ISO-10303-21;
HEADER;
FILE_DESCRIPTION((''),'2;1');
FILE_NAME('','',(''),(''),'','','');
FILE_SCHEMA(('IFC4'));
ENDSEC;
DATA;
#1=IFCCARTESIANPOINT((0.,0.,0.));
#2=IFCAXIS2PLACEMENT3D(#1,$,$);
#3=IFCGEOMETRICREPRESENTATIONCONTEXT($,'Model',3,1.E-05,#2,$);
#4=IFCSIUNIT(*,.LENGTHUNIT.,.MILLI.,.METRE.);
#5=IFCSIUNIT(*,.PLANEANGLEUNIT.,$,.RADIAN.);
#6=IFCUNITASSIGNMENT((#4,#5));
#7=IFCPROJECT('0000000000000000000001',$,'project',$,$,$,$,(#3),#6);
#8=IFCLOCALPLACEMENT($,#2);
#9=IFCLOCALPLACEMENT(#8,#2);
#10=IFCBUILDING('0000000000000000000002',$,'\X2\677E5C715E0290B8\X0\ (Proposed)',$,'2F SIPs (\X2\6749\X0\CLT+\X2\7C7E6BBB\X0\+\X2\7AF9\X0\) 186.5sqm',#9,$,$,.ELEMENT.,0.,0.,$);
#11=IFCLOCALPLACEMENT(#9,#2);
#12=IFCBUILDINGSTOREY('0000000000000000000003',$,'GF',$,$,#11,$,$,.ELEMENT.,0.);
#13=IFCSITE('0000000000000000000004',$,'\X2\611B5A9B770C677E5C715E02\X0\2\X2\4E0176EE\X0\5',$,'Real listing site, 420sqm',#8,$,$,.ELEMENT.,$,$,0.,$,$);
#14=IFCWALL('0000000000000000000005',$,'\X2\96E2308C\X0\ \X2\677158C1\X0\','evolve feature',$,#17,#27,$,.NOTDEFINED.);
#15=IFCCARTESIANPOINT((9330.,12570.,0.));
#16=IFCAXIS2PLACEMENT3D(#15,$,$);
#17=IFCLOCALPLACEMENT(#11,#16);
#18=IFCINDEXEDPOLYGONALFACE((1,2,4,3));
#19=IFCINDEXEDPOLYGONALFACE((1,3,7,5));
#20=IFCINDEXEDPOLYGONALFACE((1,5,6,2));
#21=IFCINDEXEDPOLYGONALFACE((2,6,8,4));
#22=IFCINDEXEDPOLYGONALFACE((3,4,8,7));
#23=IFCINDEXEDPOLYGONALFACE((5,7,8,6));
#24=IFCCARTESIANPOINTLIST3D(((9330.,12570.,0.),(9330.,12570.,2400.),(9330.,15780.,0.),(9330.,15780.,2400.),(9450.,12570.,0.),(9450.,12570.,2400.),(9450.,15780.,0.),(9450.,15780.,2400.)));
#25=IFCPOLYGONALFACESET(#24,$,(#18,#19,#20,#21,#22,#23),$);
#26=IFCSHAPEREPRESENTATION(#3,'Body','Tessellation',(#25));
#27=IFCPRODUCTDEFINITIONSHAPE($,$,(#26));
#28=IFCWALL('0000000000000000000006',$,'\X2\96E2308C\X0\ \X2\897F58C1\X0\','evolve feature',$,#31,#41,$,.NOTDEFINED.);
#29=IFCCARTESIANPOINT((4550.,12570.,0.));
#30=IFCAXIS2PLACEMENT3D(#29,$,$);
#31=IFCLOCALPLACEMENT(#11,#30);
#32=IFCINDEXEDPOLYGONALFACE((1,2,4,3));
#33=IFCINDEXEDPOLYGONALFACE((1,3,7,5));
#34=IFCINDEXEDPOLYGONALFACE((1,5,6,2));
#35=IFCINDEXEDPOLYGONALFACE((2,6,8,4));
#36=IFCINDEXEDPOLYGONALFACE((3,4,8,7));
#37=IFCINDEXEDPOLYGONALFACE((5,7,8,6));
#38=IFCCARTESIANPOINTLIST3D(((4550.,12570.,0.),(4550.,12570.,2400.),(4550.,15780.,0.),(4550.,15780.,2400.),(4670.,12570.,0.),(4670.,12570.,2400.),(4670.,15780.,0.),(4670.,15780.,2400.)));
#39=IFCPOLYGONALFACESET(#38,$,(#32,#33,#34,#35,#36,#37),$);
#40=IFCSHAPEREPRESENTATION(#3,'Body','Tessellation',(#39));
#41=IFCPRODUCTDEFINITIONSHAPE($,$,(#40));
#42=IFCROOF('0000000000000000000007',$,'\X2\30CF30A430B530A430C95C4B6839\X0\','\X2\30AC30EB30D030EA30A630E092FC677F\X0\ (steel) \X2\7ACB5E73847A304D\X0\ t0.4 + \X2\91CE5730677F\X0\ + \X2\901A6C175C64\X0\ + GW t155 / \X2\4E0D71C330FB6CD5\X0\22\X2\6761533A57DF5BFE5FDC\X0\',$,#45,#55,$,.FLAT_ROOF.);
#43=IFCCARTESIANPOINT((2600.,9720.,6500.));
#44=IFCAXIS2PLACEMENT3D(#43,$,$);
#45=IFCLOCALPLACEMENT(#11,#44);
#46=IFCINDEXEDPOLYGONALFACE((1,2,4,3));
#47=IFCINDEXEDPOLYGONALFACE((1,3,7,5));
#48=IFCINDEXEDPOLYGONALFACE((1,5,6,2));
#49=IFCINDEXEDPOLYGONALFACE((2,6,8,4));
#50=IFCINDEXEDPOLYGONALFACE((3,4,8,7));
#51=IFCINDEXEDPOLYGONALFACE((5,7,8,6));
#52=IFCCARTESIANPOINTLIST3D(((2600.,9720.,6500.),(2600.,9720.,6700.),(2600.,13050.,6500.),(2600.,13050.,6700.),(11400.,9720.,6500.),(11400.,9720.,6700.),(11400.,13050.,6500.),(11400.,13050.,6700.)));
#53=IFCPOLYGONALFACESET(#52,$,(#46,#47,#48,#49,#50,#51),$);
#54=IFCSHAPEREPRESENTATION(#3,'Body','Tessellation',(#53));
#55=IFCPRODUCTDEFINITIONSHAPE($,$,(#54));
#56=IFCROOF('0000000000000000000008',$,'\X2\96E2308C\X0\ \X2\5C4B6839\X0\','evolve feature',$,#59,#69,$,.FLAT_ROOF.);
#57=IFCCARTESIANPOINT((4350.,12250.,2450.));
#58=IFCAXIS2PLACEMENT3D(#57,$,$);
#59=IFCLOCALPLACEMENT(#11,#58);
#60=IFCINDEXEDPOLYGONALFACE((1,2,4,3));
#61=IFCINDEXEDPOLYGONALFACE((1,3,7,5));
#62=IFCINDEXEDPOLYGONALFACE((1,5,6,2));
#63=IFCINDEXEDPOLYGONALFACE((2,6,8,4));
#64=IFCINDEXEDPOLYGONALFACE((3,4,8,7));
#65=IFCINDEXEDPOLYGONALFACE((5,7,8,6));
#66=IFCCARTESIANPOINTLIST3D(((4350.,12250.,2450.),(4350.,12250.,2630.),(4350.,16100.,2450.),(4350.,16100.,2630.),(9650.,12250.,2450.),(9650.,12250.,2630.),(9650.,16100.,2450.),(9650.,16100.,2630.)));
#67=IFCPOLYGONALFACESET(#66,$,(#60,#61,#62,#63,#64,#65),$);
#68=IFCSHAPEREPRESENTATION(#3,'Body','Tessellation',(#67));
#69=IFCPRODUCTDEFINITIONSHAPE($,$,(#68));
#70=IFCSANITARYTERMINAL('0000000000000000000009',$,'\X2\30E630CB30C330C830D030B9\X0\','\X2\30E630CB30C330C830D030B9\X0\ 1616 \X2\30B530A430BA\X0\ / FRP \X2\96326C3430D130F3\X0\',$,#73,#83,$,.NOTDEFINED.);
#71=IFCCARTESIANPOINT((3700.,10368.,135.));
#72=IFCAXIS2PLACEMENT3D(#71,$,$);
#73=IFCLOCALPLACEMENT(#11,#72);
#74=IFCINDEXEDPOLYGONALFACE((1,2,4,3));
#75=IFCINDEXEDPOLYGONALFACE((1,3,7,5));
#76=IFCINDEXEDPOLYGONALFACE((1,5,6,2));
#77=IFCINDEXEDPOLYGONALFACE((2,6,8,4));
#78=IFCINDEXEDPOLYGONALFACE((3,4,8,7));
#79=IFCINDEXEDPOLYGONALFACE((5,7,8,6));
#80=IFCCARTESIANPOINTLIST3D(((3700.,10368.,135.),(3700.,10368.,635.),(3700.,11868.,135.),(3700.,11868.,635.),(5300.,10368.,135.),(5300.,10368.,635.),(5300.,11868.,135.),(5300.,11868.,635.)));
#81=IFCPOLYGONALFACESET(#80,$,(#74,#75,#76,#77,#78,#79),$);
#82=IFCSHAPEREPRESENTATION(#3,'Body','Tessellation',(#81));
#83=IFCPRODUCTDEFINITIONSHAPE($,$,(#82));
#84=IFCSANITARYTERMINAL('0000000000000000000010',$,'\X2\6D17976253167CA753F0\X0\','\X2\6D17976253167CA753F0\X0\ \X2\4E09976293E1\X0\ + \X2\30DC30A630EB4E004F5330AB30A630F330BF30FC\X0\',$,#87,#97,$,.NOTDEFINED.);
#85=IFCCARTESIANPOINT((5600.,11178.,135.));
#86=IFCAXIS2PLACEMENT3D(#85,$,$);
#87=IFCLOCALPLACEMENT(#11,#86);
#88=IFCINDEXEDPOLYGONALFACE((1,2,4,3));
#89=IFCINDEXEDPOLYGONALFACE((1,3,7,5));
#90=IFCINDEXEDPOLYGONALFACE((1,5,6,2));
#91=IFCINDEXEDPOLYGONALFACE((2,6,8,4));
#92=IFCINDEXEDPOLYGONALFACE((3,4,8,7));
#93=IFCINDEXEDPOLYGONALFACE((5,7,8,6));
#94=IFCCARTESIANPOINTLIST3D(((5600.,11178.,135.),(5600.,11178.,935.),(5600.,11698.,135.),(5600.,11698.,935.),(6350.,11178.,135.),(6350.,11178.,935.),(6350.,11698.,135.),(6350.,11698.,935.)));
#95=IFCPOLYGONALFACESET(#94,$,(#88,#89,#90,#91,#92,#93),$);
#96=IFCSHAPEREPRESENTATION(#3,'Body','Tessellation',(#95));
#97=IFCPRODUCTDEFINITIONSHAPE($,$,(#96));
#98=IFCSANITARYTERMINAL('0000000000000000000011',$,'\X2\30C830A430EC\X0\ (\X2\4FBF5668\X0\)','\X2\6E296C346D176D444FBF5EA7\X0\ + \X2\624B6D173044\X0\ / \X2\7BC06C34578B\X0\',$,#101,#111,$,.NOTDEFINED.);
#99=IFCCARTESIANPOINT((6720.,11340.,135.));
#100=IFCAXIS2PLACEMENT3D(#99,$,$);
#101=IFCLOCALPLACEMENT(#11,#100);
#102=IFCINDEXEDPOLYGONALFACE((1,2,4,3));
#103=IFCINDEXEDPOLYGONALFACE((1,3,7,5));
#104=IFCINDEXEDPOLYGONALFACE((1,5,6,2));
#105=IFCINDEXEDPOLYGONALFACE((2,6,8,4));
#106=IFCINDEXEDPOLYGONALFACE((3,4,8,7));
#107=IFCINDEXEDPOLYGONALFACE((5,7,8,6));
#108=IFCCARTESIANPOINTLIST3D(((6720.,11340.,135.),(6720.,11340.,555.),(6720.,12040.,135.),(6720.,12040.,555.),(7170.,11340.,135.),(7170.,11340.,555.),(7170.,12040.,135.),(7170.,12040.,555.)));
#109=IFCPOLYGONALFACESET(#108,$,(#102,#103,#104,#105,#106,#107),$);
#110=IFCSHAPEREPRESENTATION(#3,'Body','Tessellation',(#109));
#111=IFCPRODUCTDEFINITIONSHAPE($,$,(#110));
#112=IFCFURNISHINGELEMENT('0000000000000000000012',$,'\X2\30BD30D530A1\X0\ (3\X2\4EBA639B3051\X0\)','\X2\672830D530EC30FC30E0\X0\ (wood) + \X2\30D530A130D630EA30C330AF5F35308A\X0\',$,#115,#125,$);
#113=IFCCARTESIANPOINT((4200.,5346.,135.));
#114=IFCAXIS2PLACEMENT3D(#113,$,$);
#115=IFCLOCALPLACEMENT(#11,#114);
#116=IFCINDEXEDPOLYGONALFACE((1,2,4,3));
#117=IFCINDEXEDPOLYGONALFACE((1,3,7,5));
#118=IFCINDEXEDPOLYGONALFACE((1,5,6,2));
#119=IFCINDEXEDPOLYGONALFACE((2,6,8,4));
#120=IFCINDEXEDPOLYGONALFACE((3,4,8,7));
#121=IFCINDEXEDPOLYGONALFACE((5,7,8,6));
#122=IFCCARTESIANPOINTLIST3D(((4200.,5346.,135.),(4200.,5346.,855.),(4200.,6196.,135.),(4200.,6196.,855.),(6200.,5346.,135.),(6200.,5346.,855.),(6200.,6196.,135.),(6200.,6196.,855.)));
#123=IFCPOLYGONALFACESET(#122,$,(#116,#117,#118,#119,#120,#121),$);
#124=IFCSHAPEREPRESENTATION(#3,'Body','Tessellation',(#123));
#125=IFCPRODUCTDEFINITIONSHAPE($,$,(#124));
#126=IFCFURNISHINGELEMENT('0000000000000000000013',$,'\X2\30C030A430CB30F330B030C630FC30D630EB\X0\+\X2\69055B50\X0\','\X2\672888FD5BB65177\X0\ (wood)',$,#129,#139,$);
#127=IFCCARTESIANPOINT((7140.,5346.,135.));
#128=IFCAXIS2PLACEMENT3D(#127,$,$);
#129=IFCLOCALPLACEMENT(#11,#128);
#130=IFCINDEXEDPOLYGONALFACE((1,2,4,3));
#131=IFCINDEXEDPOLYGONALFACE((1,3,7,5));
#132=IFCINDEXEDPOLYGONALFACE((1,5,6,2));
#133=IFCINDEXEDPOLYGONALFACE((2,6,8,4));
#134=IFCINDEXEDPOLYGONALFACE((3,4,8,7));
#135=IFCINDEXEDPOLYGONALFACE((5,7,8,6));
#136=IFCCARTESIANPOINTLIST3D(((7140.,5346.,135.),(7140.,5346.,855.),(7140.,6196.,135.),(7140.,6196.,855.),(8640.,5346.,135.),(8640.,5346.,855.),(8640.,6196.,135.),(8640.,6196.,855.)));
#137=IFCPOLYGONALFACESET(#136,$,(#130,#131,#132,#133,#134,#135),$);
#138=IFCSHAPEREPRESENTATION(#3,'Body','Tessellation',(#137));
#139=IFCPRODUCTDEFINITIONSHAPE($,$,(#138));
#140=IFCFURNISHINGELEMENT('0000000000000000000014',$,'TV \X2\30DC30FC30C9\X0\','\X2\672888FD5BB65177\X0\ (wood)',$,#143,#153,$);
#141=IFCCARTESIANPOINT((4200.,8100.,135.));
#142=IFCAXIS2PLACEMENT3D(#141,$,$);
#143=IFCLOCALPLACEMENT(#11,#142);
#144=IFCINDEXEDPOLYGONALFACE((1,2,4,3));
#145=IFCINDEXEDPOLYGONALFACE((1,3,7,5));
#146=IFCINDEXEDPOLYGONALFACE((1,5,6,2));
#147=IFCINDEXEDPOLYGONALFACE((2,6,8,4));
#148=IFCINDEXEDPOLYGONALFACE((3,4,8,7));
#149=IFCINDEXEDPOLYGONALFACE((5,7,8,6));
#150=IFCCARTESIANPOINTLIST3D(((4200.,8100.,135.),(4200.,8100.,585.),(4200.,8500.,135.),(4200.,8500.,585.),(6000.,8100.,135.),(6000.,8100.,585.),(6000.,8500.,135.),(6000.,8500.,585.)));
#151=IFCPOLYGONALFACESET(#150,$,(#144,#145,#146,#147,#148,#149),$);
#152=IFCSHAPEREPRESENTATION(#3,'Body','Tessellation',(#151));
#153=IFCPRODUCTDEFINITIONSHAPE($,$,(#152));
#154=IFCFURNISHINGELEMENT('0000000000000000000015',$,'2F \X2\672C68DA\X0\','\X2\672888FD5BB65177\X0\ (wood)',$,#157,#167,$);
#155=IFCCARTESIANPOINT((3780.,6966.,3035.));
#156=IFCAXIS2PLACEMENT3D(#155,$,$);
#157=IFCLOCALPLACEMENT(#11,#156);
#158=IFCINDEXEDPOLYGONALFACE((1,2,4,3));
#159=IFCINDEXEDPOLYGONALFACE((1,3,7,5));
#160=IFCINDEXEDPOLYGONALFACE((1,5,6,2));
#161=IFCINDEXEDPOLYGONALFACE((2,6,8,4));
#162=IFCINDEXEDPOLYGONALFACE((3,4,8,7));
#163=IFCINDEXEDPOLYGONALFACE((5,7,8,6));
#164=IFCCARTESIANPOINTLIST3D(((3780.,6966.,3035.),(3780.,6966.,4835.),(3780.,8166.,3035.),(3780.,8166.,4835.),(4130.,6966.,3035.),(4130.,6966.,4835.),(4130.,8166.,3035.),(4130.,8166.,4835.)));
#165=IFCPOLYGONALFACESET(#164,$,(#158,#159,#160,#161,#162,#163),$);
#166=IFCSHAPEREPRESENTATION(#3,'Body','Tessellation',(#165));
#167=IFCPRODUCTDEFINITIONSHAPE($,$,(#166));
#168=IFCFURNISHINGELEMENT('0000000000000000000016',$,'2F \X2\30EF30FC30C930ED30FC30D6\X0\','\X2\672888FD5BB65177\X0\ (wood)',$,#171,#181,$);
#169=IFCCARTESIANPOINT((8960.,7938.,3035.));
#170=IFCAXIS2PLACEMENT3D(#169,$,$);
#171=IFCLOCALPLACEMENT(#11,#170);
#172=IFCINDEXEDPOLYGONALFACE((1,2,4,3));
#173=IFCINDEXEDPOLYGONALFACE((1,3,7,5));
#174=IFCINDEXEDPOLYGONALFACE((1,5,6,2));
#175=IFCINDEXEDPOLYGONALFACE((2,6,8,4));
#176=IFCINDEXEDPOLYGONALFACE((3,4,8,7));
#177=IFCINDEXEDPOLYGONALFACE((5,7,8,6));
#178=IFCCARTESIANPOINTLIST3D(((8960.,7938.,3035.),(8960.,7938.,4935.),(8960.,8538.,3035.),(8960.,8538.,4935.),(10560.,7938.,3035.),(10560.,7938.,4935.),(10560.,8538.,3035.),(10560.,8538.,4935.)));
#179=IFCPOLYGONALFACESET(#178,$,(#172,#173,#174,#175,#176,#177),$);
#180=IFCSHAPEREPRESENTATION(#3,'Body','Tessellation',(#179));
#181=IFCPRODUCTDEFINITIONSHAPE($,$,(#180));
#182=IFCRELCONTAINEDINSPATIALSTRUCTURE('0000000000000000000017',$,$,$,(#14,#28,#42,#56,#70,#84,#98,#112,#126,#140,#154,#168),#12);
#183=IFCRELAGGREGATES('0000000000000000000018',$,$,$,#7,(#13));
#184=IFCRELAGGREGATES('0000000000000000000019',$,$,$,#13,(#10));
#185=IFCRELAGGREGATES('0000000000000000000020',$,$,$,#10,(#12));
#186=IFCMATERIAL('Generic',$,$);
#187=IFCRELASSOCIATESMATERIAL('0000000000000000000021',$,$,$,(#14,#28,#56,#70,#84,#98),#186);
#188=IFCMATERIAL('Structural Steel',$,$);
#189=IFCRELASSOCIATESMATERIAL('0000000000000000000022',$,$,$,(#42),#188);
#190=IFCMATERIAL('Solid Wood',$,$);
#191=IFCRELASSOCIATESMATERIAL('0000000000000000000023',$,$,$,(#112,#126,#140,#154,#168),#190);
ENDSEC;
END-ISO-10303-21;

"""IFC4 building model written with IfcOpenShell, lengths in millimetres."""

from ifc_helpers import new_model, si_unit, frame, frame_2d, origin, place, context, project, spatial, rectangle, extrude, material, element, save


model = new_model("IFC4")

# Units and contexts
model_context = context("Model", 3, precision=1e-05, world=origin())
ifc_project = project(units=[si_unit("LENGTHUNIT", "METRE", prefix="MILLI"), si_unit("PLANEANGLEUNIT", "RADIAN")], contexts=[model_context])

# Site, building, storey
site_placement = place(None, origin())
site = spatial("IfcSite", under=ifc_project, at=site_placement, Name="愛媛県松山市2丁目5", ObjectType="Real listing site, 420sqm", CompositionType="ELEMENT", RefElevation=0.0)
building_placement = place(site_placement, origin())
building = spatial("IfcBuilding", under=site, at=building_placement, Name="松山市邸 (Proposed)", ObjectType="2F SIPs (杉CLT+籾殻+竹) 186.5sqm", CompositionType="ELEMENT", ElevationOfRefHeight=0.0, ElevationOfTerrain=0.0)
storey_placement = place(building_placement, origin())
storey = spatial("IfcBuildingStorey", under=building, at=storey_placement, Name="GF", CompositionType="ELEMENT", Elevation=0.0)

# Shared definitions
ifc_material_1 = material(Name="Generic")

# Shared definitions
ifc_material_2 = material(Name="Solid Wood")

# Walls
wall_1_placement = place(storey_placement, frame((9330.0, 12570.0, 0.0)))
element("IfcWall", 1, at=wall_1_placement, inside=storey, material=ifc_material_1, Name="離れ 東壁", Description="evolve feature", PredefinedType="NOTDEFINED", context=model_context, shape_type="SweptSolid", body=[
    extrude(rectangle(XDim=120.0, YDim=3210.0, at=frame_2d((60.0, 1605.0))), frame((9330.0, 12570.0, 0.0)), (0.0, 0.0, 1.0), 2400.0),
])
wall_2_placement = place(storey_placement, frame((4550.0, 12570.0, 0.0)))
element("IfcWall", 2, at=wall_2_placement, inside=storey, material=ifc_material_1, Name="離れ 西壁", Description="evolve feature", PredefinedType="NOTDEFINED", context=model_context, shape_type="SweptSolid", body=[
    extrude(rectangle(XDim=120.0, YDim=3210.0, at=frame_2d((60.0, 1605.0))), frame((4550.0, 12570.0, 0.0)), (0.0, 0.0, 1.0), 2400.0),
])

# Roofs
ifc_material_3 = material(Name="Structural Steel")
roof_1_placement = place(storey_placement, frame((2600.0, 9720.0, 6500.0)))
element("IfcRoof", 3, at=roof_1_placement, inside=storey, material=ifc_material_3, Name="ハイサイド屋根", Description="ガルバリウム鋼板 (steel) 立平葺き t0.4 + 野地板 + 通気層 + GW t155 / 不燃・法22条区域対応", PredefinedType="FLAT_ROOF", context=model_context, shape_type="SweptSolid", body=[
    extrude(rectangle(XDim=8800.0, YDim=3330.0, at=frame_2d((4400.0, 1665.0))), frame((2600.0, 9720.0, 6500.0)), (0.0, 0.0, 1.0), 200.0),
])
roof_2_placement = place(storey_placement, frame((4350.0, 12250.0, 2450.0)))
element("IfcRoof", 4, at=roof_2_placement, inside=storey, material=ifc_material_1, Name="離れ 屋根", Description="evolve feature", PredefinedType="FLAT_ROOF", context=model_context, shape_type="SweptSolid", body=[
    extrude(rectangle(XDim=5300.0, YDim=3850.0, at=frame_2d((2650.0, 1925.0))), frame((4350.0, 12250.0, 2450.0)), (0.0, 0.0, 1.0), 180.0),
])

# Sanitary terminals
sanitary_terminal_1_placement = place(storey_placement, frame((3700.0, 10368.0, 135.0)))
element("IfcSanitaryTerminal", 5, at=sanitary_terminal_1_placement, inside=storey, material=ifc_material_1, Name="ユニットバス", Description="ユニットバス 1616 サイズ / FRP 防水パン", PredefinedType="NOTDEFINED", context=model_context, shape_type="SweptSolid", body=[
    extrude(rectangle(XDim=1600.0, YDim=1500.0, at=frame_2d((800.0, 750.0))), frame((3700.0, 10368.0, 135.0)), (0.0, 0.0, 1.0), 500.0),
])
sanitary_terminal_2_placement = place(storey_placement, frame((5600.0, 11178.0, 135.0)))
element("IfcSanitaryTerminal", 6, at=sanitary_terminal_2_placement, inside=storey, material=ifc_material_1, Name="洗面化粧台", Description="洗面化粧台 三面鏡 + ボウル一体カウンター", PredefinedType="NOTDEFINED", context=model_context, shape_type="SweptSolid", body=[
    extrude(rectangle(XDim=750.0, YDim=520.0, at=frame_2d((375.0, 260.0))), frame((5600.0, 11178.0, 135.0)), (0.0, 0.0, 1.0), 800.0),
])
sanitary_terminal_3_placement = place(storey_placement, frame((6720.0, 11340.0, 135.0)))
element("IfcSanitaryTerminal", 7, at=sanitary_terminal_3_placement, inside=storey, material=ifc_material_1, Name="トイレ (便器)", Description="温水洗浄便座 + 手洗い / 節水型", PredefinedType="NOTDEFINED", context=model_context, shape_type="SweptSolid", body=[
    extrude(rectangle(XDim=450.0, YDim=700.0, at=frame_2d((225.0, 350.0))), frame((6720.0, 11340.0, 135.0)), (0.0, 0.0, 1.0), 420.0),
])

# Furnishing elements
furnishing_1_placement = place(storey_placement, frame((4200.0, 5346.0, 135.0)))
element("IfcFurnishingElement", 8, at=furnishing_1_placement, inside=storey, material=ifc_material_2, Name="ソファ (3人掛け)", Description="木フレーム (wood) + ファブリック張り", context=model_context, shape_type="SweptSolid", body=[
    extrude(rectangle(XDim=2000.0, YDim=850.0, at=frame_2d((1000.0, 425.0))), frame((4200.0, 5346.0, 135.0)), (0.0, 0.0, 1.0), 720.0),
])
furnishing_2_placement = place(storey_placement, frame((7140.0, 5346.0, 135.0)))
element("IfcFurnishingElement", 9, at=furnishing_2_placement, inside=storey, material=ifc_material_2, Name="ダイニングテーブル+椅子", Description="木製家具 (wood)", context=model_context, shape_type="SweptSolid", body=[
    extrude(rectangle(XDim=1500.0, YDim=850.0, at=frame_2d((750.0, 425.0))), frame((7140.0, 5346.0, 135.0)), (0.0, 0.0, 1.0), 720.0),
])
furnishing_3_placement = place(storey_placement, frame((4200.0, 8100.0, 135.0)))
element("IfcFurnishingElement", 10, at=furnishing_3_placement, inside=storey, material=ifc_material_2, Name="TV ボード", Description="木製家具 (wood)", context=model_context, shape_type="SweptSolid", body=[
    extrude(rectangle(XDim=1800.0, YDim=400.0, at=frame_2d((900.0, 200.0))), frame((4200.0, 8100.0, 135.0)), (0.0, 0.0, 1.0), 450.0),
])
furnishing_4_placement = place(storey_placement, frame((3780.0, 6966.0, 3035.0)))
element("IfcFurnishingElement", 11, at=furnishing_4_placement, inside=storey, material=ifc_material_2, Name="2F 本棚", Description="木製家具 (wood)", context=model_context, shape_type="SweptSolid", body=[
    extrude(rectangle(XDim=350.0, YDim=1200.0, at=frame_2d((175.0, 600.0))), frame((3780.0, 6966.0, 3035.0)), (0.0, 0.0, 1.0), 1800.0),
])
furnishing_5_placement = place(storey_placement, frame((8960.0, 7938.0, 3035.0)))
element("IfcFurnishingElement", 12, at=furnishing_5_placement, inside=storey, material=ifc_material_2, Name="2F ワードローブ", Description="木製家具 (wood)", context=model_context, shape_type="SweptSolid", body=[
    extrude(rectangle(XDim=1600.0, YDim=600.0, at=frame_2d((800.0, 300.0))), frame((8960.0, 7938.0, 3035.0)), (0.0, 0.0, 1.0), 1900.0),
])

save(model, "model.ifc")
